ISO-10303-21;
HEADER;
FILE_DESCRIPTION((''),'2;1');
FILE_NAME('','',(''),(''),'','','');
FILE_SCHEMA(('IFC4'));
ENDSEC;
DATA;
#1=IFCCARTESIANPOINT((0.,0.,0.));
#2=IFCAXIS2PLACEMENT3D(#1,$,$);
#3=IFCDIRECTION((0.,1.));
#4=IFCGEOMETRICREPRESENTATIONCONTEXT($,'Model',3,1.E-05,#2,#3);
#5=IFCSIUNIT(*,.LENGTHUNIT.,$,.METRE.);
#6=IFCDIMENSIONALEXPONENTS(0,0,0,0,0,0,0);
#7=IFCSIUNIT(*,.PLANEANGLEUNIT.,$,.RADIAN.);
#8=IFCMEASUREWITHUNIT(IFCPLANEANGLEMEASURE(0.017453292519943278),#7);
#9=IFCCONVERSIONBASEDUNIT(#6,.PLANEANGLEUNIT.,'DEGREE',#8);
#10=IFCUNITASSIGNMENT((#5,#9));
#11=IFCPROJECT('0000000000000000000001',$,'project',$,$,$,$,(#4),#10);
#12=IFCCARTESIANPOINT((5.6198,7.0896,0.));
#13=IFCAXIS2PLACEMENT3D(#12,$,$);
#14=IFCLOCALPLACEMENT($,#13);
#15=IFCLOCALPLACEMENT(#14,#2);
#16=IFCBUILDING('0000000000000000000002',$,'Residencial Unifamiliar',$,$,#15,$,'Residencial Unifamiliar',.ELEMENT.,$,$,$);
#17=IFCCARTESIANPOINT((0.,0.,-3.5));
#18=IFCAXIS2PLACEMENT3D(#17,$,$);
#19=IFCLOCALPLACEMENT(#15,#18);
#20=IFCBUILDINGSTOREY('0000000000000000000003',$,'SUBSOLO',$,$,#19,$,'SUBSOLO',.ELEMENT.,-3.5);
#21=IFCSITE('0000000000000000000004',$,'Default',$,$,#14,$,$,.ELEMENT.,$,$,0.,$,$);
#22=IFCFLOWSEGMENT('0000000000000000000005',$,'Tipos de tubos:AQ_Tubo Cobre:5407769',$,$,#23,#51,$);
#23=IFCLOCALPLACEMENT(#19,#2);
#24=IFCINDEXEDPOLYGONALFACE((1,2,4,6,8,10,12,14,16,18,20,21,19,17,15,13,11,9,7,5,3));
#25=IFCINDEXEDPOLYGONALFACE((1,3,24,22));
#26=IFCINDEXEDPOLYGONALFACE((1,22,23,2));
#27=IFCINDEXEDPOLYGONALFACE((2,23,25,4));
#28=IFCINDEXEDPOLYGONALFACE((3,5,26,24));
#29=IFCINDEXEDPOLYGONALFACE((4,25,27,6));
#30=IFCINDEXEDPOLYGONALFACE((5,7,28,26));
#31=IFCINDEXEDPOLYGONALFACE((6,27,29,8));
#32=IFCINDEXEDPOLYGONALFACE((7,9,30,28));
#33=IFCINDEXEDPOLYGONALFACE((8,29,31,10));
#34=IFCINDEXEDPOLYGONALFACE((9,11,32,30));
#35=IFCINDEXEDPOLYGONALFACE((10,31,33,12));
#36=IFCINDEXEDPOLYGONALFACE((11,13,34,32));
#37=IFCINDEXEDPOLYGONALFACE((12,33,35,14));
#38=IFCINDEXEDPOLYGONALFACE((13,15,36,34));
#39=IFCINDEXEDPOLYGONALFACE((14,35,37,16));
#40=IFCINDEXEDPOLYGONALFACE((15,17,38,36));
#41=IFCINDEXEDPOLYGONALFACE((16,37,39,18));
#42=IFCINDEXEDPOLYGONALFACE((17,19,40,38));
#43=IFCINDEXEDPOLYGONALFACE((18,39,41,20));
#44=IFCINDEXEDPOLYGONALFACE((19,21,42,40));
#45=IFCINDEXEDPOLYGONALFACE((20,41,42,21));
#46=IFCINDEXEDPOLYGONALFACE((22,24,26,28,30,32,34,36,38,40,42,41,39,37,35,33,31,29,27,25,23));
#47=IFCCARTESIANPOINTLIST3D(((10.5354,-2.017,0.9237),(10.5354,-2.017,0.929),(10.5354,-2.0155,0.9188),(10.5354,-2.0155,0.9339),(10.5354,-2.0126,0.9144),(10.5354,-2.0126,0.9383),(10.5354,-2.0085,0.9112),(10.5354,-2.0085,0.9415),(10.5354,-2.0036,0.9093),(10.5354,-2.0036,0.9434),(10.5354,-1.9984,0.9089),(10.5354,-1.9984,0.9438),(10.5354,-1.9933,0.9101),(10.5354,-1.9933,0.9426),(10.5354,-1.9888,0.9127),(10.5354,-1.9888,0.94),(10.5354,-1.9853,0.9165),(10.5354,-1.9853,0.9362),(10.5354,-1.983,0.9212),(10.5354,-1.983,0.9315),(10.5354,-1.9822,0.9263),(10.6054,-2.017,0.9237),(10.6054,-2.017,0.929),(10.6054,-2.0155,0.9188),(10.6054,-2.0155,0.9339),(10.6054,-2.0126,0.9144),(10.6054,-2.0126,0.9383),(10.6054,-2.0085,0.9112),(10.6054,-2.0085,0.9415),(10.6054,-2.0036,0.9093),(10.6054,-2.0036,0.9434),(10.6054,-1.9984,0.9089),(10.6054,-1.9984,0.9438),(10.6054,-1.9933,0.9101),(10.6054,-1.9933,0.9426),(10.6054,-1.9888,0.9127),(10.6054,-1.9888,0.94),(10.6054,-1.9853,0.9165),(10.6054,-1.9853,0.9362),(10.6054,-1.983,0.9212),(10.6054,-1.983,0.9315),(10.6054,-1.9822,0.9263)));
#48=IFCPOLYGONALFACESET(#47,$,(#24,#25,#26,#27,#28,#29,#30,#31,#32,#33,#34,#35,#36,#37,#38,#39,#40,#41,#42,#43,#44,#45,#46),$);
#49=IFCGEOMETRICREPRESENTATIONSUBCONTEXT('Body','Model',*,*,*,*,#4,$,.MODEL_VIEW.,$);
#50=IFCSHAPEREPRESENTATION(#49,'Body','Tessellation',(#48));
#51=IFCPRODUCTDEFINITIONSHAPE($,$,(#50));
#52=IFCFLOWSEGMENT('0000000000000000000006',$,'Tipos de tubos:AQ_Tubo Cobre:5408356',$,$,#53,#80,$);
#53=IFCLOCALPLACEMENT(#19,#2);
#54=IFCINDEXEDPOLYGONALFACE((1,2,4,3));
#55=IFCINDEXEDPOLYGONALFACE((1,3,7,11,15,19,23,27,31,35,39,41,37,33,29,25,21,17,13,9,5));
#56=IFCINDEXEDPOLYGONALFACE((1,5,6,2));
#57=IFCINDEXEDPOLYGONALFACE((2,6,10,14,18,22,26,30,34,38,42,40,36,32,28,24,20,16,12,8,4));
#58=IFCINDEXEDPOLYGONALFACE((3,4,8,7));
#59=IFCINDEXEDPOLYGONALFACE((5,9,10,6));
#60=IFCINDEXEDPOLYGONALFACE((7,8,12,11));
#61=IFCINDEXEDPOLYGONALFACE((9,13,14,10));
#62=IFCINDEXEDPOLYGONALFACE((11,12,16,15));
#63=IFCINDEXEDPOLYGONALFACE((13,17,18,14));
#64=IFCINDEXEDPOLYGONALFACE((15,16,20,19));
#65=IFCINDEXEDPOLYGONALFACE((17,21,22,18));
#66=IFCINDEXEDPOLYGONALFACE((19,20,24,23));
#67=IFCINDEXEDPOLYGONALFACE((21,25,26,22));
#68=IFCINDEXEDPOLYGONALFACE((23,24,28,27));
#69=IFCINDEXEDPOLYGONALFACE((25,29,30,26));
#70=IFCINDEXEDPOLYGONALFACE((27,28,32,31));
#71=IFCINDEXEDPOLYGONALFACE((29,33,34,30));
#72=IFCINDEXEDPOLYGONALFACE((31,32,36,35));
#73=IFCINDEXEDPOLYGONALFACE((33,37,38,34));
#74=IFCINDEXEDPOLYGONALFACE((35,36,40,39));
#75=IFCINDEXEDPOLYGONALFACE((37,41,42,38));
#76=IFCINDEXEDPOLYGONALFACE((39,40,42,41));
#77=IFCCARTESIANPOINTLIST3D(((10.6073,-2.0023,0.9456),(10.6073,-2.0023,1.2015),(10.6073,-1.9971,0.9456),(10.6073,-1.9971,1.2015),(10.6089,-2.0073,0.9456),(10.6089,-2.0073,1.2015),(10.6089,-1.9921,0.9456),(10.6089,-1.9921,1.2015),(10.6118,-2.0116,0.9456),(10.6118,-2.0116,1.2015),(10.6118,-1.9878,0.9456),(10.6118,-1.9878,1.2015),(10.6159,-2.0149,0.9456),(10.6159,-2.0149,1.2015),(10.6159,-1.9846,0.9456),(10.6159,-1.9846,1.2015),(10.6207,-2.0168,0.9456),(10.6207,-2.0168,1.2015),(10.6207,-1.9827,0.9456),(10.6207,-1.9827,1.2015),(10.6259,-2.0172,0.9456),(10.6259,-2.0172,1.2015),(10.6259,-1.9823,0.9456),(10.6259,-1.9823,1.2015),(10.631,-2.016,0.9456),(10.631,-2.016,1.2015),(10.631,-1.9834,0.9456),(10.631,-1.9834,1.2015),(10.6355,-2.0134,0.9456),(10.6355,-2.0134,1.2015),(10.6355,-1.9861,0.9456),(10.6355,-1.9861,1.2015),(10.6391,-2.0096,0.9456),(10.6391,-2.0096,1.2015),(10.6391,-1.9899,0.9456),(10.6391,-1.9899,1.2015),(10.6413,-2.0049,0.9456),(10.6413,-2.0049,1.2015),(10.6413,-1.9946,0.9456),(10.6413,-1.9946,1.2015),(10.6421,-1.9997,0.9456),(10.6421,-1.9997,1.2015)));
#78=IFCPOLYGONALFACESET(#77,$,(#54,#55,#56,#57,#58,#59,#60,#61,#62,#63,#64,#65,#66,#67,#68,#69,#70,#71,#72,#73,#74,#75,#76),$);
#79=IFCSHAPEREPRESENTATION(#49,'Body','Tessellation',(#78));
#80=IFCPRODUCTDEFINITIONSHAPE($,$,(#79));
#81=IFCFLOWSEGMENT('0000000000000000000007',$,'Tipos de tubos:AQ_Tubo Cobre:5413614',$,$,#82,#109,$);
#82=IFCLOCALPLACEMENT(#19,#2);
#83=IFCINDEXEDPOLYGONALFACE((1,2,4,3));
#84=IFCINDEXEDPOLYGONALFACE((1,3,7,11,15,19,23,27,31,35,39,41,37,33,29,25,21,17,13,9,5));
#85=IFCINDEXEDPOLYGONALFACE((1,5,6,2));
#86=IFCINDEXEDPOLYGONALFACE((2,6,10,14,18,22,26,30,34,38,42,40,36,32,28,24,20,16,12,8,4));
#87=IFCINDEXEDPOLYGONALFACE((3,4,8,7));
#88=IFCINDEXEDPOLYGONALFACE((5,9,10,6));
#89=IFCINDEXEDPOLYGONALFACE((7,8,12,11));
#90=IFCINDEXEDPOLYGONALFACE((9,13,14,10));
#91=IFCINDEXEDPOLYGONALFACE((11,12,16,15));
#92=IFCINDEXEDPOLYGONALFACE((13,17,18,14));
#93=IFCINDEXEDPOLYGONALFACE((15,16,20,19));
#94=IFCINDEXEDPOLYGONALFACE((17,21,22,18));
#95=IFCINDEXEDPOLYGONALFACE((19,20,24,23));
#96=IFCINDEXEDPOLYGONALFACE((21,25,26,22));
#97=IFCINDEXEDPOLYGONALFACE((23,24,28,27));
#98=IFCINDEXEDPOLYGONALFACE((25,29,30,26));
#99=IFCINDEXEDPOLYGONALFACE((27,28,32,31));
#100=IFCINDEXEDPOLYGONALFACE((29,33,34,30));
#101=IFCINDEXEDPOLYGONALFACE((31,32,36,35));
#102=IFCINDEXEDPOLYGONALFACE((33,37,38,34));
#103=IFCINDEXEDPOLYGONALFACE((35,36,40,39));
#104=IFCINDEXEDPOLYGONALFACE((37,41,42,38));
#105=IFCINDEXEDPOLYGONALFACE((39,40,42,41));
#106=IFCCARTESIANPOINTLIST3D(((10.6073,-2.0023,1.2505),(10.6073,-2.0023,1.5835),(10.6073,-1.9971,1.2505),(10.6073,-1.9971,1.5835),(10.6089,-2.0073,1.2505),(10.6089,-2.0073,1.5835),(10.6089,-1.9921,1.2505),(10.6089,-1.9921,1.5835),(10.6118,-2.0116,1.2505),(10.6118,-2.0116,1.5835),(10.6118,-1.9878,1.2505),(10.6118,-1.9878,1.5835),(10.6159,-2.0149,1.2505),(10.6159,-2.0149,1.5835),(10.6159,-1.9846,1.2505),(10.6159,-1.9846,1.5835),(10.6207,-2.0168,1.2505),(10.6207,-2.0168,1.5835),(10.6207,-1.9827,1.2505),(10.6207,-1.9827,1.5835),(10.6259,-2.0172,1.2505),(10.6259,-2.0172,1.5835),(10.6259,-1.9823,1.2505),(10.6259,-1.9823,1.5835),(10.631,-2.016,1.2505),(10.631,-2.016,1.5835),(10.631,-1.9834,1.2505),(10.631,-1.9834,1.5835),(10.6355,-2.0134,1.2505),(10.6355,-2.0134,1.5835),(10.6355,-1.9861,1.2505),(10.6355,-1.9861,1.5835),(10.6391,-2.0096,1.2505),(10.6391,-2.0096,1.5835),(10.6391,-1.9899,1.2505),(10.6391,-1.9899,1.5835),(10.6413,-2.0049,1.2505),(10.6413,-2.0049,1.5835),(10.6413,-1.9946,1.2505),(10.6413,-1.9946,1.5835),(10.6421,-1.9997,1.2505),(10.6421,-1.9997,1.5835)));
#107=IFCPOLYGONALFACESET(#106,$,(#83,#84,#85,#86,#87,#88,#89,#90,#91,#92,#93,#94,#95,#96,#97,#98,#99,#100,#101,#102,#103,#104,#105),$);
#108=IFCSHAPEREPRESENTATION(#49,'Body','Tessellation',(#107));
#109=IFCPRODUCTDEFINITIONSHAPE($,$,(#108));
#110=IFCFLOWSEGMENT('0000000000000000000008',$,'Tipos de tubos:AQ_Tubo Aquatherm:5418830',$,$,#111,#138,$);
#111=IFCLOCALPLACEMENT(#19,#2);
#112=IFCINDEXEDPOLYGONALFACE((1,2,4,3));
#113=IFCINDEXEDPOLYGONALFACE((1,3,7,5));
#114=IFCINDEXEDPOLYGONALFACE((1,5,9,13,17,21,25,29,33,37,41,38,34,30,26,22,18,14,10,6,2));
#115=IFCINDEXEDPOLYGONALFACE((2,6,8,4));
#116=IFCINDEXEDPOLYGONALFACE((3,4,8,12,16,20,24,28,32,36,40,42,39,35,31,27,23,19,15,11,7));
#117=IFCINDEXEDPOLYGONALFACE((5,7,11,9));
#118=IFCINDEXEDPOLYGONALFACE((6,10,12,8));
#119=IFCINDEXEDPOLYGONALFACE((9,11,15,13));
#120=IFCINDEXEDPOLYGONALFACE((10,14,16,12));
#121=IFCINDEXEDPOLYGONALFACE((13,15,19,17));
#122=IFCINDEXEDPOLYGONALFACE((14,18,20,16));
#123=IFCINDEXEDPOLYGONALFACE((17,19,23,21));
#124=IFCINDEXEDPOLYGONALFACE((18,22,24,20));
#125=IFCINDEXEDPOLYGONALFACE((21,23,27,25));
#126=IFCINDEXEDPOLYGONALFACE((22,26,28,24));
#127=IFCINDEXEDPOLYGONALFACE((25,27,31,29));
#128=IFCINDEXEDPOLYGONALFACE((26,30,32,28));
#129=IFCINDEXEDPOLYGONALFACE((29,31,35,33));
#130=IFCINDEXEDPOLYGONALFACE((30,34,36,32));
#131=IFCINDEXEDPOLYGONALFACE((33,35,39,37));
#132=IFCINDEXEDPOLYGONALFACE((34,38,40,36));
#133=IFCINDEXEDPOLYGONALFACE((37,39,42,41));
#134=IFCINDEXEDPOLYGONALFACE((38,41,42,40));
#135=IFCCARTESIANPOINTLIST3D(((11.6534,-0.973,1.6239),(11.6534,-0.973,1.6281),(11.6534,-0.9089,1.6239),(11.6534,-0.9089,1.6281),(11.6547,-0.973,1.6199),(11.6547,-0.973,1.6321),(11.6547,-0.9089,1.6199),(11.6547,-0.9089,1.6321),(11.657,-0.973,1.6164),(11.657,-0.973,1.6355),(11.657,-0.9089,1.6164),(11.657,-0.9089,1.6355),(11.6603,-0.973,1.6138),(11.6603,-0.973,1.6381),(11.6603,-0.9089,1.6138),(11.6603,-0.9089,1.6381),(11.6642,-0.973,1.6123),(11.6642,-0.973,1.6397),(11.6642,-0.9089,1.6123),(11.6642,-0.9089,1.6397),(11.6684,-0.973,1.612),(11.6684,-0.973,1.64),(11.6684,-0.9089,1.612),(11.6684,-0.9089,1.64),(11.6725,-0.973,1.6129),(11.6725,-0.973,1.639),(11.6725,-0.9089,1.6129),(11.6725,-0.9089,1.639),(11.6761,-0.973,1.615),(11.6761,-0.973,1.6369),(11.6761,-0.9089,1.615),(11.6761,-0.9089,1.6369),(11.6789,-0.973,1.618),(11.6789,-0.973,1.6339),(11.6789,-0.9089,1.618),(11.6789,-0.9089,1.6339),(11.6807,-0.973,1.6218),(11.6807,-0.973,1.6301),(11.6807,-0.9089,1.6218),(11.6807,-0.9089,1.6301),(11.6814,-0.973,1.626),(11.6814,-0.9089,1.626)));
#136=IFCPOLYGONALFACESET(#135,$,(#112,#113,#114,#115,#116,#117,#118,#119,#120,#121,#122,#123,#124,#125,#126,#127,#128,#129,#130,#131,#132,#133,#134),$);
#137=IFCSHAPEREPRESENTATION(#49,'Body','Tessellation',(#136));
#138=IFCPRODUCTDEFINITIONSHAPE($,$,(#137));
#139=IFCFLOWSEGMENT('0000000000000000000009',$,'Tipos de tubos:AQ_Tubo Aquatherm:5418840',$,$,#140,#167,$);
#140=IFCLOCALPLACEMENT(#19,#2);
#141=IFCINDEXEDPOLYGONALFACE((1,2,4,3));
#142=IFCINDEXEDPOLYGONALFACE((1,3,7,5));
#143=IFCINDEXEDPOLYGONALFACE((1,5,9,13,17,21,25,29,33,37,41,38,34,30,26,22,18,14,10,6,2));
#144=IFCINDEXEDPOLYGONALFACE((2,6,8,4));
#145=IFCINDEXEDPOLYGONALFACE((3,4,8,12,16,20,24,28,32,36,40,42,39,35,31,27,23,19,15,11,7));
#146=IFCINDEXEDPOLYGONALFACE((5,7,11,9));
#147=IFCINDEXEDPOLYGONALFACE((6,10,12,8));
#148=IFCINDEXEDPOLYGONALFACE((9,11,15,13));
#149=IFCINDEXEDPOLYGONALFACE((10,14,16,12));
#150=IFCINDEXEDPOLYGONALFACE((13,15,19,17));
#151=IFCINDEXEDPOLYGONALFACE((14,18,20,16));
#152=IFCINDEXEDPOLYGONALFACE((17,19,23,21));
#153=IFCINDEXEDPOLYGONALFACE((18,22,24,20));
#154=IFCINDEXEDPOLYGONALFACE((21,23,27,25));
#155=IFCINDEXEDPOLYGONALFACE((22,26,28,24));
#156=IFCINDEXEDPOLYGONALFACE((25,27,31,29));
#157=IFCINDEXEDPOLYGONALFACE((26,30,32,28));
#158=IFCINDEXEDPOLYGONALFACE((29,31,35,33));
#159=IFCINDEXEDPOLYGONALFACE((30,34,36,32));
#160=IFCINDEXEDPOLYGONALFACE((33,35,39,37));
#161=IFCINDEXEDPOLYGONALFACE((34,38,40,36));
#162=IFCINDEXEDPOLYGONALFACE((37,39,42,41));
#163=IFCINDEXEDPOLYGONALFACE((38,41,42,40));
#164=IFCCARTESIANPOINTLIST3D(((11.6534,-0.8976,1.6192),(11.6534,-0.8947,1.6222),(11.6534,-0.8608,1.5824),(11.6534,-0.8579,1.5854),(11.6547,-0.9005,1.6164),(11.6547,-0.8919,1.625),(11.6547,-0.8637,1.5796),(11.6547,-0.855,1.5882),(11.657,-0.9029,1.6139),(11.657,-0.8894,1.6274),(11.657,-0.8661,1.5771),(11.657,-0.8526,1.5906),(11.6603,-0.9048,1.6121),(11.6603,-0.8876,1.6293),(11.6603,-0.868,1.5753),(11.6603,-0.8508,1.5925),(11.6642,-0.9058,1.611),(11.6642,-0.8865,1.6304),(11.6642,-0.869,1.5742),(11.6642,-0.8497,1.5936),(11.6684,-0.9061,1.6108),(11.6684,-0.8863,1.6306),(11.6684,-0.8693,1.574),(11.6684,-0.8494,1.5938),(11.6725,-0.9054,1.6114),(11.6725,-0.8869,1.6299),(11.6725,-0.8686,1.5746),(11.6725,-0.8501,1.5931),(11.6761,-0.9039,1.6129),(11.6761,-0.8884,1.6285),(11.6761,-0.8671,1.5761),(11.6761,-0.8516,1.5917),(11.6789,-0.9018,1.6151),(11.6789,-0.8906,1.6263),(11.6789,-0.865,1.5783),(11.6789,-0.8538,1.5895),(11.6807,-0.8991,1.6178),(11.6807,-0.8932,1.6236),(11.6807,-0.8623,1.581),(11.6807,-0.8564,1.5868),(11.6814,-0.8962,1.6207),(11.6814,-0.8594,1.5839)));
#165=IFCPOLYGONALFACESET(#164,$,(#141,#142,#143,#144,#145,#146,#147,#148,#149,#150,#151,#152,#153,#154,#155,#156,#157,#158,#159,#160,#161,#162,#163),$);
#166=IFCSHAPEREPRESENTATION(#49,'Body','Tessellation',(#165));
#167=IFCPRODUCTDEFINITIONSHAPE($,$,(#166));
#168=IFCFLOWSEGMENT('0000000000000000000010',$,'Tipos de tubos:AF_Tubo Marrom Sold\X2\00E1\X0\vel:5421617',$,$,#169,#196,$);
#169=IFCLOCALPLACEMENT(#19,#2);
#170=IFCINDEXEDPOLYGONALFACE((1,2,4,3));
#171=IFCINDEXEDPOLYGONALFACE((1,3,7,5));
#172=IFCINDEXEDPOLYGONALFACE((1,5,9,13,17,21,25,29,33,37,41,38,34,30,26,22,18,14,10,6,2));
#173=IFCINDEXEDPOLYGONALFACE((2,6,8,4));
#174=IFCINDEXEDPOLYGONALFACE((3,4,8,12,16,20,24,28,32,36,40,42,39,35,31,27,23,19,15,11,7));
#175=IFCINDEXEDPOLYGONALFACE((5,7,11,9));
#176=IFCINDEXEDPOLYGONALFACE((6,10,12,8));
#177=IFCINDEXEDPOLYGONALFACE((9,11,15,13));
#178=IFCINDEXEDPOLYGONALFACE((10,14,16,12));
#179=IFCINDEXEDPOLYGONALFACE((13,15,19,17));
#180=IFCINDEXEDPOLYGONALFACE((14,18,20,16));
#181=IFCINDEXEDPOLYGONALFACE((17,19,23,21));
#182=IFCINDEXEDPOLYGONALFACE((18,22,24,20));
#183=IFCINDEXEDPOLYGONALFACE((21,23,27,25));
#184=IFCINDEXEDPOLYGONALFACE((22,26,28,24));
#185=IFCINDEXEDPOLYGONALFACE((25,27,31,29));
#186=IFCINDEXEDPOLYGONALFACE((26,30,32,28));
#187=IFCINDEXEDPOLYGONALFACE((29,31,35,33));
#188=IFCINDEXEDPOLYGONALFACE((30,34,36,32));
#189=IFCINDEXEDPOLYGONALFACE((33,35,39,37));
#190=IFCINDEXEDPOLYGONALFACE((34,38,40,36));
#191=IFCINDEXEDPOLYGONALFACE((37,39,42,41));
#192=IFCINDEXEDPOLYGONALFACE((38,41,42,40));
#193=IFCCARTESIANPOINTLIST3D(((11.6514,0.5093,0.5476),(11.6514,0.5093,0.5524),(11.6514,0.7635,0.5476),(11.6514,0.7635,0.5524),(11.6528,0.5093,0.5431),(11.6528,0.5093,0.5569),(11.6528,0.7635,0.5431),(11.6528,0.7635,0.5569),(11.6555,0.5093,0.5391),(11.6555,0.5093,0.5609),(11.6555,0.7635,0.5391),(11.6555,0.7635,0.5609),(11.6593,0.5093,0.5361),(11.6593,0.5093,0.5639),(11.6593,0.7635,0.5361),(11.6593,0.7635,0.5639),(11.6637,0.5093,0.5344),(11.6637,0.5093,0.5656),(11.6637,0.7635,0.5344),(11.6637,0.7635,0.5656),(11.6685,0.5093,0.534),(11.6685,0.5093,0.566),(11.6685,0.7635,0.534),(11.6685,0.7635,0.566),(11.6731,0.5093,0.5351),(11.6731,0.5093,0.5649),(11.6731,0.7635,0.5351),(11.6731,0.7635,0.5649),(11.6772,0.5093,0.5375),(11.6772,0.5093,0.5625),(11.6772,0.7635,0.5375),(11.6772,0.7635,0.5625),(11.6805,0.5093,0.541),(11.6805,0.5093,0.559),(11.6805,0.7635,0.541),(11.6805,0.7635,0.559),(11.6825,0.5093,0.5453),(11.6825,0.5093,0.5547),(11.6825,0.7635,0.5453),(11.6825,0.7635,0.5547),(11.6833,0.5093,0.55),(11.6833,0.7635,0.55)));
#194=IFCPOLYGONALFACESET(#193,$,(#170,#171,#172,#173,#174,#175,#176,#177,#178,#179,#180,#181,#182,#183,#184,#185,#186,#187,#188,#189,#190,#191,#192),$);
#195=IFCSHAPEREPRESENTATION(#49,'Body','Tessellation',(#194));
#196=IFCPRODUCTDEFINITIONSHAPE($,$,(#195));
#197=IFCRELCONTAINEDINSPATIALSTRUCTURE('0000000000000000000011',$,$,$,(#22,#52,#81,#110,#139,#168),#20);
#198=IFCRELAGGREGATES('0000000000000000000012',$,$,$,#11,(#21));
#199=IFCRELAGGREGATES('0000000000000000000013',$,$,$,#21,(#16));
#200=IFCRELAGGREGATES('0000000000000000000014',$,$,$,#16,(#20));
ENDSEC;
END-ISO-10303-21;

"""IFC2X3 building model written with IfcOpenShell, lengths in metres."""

from ifc_helpers import new_model, entity, si_unit, converted_unit, direction, frame, frame_2d, origin, origin_2d_with_axis, place, context, subcontext, project, spatial, circle, extrude, element, save


model = new_model("IFC2X3")

# Units and contexts
model_context = context("Model", 3, precision=1e-05, world=origin(), true_north=direction((0.0, 1.0)))
body_context = subcontext(model_context, "Body", "Model", "MODEL_VIEW")
ifc_project = project(units=[si_unit("LENGTHUNIT", "METRE"), converted_unit("PLANEANGLEUNIT", "DEGREE", entity("IfcPlaneAngleMeasure", 0.017453292519943278), si_unit("PLANEANGLEUNIT", "RADIAN"), dimensions=[0, 0, 0, 0, 0, 0, 0])], contexts=[model_context])

# Site, building, storey
site_placement = place(None, frame((5.6198, 7.0896, 0.0)))
site = spatial("IfcSite", under=ifc_project, at=site_placement, Name="Default", CompositionType="ELEMENT", RefElevation=0.0)
building_placement = place(site_placement, origin())
building = spatial("IfcBuilding", under=site, at=building_placement, Name="Residencial Unifamiliar", LongName="Residencial Unifamiliar", CompositionType="ELEMENT")
storey_placement = place(building_placement, frame((0.0, 0.0, -3.5)))
storey = spatial("IfcBuildingStorey", under=building, at=storey_placement, Name="SUBSOLO", LongName="SUBSOLO", CompositionType="ELEMENT", Elevation=-3.5)

# Flow segments
flow_segment_1_placement = place(storey_placement, origin())
element("IfcFlowSegment", 1, at=flow_segment_1_placement, inside=storey, Name="Tipos de tubos:AQ_Tubo Cobre:5407769", context=body_context, shape_type="SweptSolid", body=[
    extrude(circle(Radius=0.0175, at=origin_2d_with_axis()), frame((10.5354, -1.9997, 0.9263), z_axis=(1.0, 0.0, 0.0), x_axis=(0.0, 1.0, 0.0)), (0.0, 0.0, 1.0), 0.07),
])
flow_segment_2_placement = place(storey_placement, origin())
element("IfcFlowSegment", 2, at=flow_segment_2_placement, inside=storey, Name="Tipos de tubos:AQ_Tubo Cobre:5408356", context=body_context, shape_type="SweptSolid", body=[
    extrude(circle(Radius=0.0175, at=origin_2d_with_axis()), frame((10.6246, -1.9997, 0.9456)), (0.0, 0.0, 1.0), 0.2559),
])
flow_segment_3_placement = place(storey_placement, origin())
element("IfcFlowSegment", 3, at=flow_segment_3_placement, inside=storey, Name="Tipos de tubos:AQ_Tubo Cobre:5413614", context=body_context, shape_type="SweptSolid", body=[
    extrude(circle(Radius=0.0175, at=origin_2d_with_axis()), frame((10.6246, -1.9997, 1.2505)), (0.0, 0.0, 1.0), 0.333),
])
flow_segment_4_placement = place(storey_placement, origin())
element("IfcFlowSegment", 4, at=flow_segment_4_placement, inside=storey, Name="Tipos de tubos:AQ_Tubo Aquatherm:5418830", context=body_context, shape_type="SweptSolid", body=[
    extrude(circle(Radius=0.0141, at=origin_2d_with_axis()), frame((11.6673, -0.973, 1.626), z_axis=(0.0, 1.0, 0.0), x_axis=(1.0, 0.0, 0.0)), (0.0, 0.0, 1.0), 0.0641),
])
flow_segment_5_placement = place(storey_placement, origin())
element("IfcFlowSegment", 5, at=flow_segment_5_placement, inside=storey, Name="Tipos de tubos:AQ_Tubo Aquatherm:5418840", context=body_context, shape_type="SweptSolid", body=[
    extrude(circle(Radius=0.0141, at=frame_2d((0.0, 0.0), x_axis=(1.0, 0.0))), frame((11.6673, -0.8962, 1.6207), z_axis=(0.0, 0.707107, -0.707107), x_axis=(1.0, 0.0, 0.0)), (0.0, 0.0, 1.0), 0.0521),
])
flow_segment_6_placement = place(storey_placement, origin())
element("IfcFlowSegment", 6, at=flow_segment_6_placement, inside=storey, Name="Tipos de tubos:AF_Tubo Marrom Soldável:5421617", context=body_context, shape_type="SweptSolid", body=[
    extrude(circle(Radius=0.016, at=origin_2d_with_axis()), frame((11.6673, 0.5093, 0.55), z_axis=(0.0, 1.0, 0.0), x_axis=(1.0, 0.0, 0.0)), (0.0, 0.0, 1.0), 0.2542),
])

save(model, "model.ifc")
